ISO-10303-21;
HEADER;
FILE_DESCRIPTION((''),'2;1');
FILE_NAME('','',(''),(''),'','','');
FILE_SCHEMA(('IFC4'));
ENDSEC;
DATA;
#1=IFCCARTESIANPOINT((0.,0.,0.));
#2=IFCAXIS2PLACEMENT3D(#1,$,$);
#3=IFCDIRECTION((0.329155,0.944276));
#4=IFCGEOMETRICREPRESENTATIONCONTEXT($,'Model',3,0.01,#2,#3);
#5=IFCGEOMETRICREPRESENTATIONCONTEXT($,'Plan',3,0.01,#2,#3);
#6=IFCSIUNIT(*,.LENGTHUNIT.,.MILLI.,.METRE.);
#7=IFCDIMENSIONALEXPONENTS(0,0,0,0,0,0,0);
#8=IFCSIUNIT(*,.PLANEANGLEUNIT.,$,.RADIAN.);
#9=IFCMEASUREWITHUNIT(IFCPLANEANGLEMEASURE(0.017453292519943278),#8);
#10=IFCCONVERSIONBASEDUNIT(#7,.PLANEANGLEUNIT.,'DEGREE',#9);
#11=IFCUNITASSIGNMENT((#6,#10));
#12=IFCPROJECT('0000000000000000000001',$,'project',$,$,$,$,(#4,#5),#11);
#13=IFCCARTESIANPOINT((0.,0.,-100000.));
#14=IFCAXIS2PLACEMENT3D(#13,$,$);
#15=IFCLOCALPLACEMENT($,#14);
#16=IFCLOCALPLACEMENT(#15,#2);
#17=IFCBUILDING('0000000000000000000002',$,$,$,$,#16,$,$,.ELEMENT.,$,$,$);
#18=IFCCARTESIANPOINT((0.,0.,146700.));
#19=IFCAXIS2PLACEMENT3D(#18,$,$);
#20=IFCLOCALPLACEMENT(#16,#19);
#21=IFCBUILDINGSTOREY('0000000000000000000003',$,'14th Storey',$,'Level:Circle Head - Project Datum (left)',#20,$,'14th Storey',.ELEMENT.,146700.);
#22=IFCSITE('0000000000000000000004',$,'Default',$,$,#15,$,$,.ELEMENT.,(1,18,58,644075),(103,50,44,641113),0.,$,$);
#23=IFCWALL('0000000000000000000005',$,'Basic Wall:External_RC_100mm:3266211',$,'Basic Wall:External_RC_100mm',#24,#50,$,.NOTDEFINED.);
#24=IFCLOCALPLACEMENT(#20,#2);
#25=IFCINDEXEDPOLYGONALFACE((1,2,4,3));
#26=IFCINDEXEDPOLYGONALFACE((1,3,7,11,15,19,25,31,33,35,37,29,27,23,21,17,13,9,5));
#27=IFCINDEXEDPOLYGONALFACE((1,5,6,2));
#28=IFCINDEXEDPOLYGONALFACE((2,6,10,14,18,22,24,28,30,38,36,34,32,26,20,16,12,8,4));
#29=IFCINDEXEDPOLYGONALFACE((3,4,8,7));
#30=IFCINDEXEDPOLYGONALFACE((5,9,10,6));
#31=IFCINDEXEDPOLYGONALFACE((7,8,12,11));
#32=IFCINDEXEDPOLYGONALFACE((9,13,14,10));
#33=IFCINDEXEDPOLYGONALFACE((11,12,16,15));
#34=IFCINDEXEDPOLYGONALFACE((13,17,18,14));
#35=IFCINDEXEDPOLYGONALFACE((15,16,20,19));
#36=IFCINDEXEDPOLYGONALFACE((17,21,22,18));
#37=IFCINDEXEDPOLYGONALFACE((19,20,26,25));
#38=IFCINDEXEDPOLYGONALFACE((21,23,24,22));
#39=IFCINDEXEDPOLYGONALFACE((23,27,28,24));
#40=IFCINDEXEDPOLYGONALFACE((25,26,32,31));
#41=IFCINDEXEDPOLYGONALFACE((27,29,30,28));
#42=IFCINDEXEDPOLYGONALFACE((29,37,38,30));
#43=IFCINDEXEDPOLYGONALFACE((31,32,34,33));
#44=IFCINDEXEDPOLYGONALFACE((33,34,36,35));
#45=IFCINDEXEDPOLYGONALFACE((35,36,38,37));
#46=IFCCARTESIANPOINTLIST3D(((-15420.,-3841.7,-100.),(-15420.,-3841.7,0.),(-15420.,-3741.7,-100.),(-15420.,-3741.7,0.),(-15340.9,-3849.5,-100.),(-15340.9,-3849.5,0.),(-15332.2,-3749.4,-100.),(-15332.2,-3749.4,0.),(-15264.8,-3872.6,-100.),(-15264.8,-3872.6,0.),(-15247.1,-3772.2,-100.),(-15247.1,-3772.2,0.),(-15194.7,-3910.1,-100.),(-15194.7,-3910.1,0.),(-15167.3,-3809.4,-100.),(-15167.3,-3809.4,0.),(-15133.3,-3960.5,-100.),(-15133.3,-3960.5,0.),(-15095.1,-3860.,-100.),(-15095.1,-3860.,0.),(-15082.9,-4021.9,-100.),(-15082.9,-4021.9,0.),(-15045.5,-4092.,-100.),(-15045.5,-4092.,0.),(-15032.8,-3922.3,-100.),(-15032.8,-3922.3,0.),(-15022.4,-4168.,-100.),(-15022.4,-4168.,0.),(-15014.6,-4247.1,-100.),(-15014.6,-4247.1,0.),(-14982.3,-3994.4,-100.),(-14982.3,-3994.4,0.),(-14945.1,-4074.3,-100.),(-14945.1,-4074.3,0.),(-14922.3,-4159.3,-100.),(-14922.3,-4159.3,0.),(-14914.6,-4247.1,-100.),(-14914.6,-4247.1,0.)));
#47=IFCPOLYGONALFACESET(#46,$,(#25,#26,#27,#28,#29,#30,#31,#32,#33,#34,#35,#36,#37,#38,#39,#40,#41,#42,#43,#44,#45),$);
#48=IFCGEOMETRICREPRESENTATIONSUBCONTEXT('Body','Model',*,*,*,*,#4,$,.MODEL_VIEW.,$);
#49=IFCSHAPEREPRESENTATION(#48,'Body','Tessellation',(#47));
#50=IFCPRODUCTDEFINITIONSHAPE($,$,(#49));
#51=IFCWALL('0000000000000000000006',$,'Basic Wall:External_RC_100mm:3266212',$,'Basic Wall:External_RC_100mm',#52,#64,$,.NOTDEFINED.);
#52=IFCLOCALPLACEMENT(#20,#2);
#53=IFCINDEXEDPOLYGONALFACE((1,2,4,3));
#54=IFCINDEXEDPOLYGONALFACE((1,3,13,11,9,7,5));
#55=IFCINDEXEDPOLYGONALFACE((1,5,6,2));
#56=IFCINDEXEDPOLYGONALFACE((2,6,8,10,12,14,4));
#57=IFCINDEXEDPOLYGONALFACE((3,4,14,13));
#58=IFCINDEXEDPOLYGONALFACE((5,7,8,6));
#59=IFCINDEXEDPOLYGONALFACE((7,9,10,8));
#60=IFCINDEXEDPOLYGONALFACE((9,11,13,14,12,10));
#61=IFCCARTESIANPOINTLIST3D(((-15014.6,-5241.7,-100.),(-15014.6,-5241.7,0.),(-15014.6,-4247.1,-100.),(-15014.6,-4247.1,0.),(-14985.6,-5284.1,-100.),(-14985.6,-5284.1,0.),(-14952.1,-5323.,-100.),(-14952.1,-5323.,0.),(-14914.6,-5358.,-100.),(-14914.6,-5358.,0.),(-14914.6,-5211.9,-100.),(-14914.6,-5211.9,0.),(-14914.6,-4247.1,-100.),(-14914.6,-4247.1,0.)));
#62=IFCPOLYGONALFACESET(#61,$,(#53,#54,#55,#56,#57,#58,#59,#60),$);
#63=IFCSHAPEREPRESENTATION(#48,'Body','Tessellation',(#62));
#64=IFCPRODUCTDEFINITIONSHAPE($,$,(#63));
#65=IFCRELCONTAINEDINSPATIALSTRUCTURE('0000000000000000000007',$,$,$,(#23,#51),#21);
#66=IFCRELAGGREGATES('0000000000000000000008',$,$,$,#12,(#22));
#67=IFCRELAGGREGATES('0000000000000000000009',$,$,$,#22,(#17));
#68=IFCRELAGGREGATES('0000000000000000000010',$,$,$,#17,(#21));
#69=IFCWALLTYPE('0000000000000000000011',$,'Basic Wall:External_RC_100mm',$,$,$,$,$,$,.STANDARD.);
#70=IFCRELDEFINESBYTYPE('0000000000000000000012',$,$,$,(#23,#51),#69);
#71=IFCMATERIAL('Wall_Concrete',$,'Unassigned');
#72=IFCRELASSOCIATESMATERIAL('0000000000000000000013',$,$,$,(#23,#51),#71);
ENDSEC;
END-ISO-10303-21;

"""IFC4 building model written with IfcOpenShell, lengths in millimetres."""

from ifc_helpers import new_model, entity, si_unit, converted_unit, direction, frame, origin, place, context, subcontext, project, spatial, line, arc, indexed_curve, outline, extrude, material, type_object, element, save


model = new_model("IFC4")

# Units and contexts
model_context = context("Model", 3, precision=0.01, world=origin(), true_north=direction((0.329155, 0.944276)))
plan_context = context("Plan", 3, precision=0.01, world=origin(), true_north=direction((0.329155, 0.944276)))
body_context = subcontext(model_context, "Body", "Model", "MODEL_VIEW")
ifc_project = project(units=[si_unit("LENGTHUNIT", "METRE", prefix="MILLI"), converted_unit("PLANEANGLEUNIT", "DEGREE", entity("IfcPlaneAngleMeasure", 0.017453292519943278), si_unit("PLANEANGLEUNIT", "RADIAN"), dimensions=[0, 0, 0, 0, 0, 0, 0])], contexts=[model_context, plan_context])

# Site, building, storey
site_placement = place(None, frame((0.0, 0.0, -100000.0)))
site = spatial("IfcSite", under=ifc_project, at=site_placement, Name="Default", CompositionType="ELEMENT", RefLatitude=(1, 18, 58, 644075), RefLongitude=(103, 50, 44, 641113), RefElevation=0.0)
building_placement = place(site_placement, origin())
building = spatial("IfcBuilding", under=site, at=building_placement, CompositionType="ELEMENT")
storey_placement = place(building_placement, frame((0.0, 0.0, 146700.0)))
storey = spatial("IfcBuildingStorey", under=building, at=storey_placement, Name="14th Storey", ObjectType="Level:Circle Head - Project Datum (left)", LongName="14th Storey", CompositionType="ELEMENT", Elevation=146700.0)

# Walls
ifc_material_1 = material(Name="Wall_Concrete", Category="Unassigned")
wall_type_1 = type_object("IfcWallType", Name="Basic Wall:External_RC_100mm", PredefinedType="STANDARD")
wall_1_placement = place(storey_placement, frame((-15420.0, -3791.7, -100.0)))
element("IfcWall", 1, at=wall_1_placement, inside=storey, type_object=wall_type_1, material=ifc_material_1, Name="Basic Wall:External_RC_100mm:3266211", ObjectType="Basic Wall:External_RC_100mm", PredefinedType="NOTDEFINED", context=body_context, shape_type="SweptSolid", body=[
    extrude(outline(indexed_curve([(505.4, -455.4), (357.3, -98.0), (0.0, 50.0), (0.0, -50.0), (286.6, -168.7), (405.4, -455.4)], segments=[arc(1, 2, 3), line(3, 4), arc(4, 5, 6), line(6, 1)], self_intersect=False)), origin(), (0.0, 0.0, 1.0), 100.0),
])
wall_2_placement = place(storey_placement, frame((-14964.6, -4247.1, -100.0), z_axis=(0.0, 0.0, 1.0), x_axis=(0.0, -1.0, 0.0)))
element("IfcWall", 2, at=wall_2_placement, inside=storey, type_object=wall_type_1, material=ifc_material_1, Name="Basic Wall:External_RC_100mm:3266212", ObjectType="Basic Wall:External_RC_100mm", PredefinedType="NOTDEFINED", context=body_context, shape_type="SweptSolid", body=[
    extrude(outline(indexed_curve([(994.6, -50.0), (1056.9, -4.8), (1110.9, 50.0), (964.8, 50.0), (0.0, 50.0), (0.0, -50.0)], segments=[arc(1, 2, 3), line(3, 4, 5, 6, 1)], self_intersect=False)), origin(), (0.0, 0.0, 1.0), 100.0),
])

save(model, "model.ifc")
